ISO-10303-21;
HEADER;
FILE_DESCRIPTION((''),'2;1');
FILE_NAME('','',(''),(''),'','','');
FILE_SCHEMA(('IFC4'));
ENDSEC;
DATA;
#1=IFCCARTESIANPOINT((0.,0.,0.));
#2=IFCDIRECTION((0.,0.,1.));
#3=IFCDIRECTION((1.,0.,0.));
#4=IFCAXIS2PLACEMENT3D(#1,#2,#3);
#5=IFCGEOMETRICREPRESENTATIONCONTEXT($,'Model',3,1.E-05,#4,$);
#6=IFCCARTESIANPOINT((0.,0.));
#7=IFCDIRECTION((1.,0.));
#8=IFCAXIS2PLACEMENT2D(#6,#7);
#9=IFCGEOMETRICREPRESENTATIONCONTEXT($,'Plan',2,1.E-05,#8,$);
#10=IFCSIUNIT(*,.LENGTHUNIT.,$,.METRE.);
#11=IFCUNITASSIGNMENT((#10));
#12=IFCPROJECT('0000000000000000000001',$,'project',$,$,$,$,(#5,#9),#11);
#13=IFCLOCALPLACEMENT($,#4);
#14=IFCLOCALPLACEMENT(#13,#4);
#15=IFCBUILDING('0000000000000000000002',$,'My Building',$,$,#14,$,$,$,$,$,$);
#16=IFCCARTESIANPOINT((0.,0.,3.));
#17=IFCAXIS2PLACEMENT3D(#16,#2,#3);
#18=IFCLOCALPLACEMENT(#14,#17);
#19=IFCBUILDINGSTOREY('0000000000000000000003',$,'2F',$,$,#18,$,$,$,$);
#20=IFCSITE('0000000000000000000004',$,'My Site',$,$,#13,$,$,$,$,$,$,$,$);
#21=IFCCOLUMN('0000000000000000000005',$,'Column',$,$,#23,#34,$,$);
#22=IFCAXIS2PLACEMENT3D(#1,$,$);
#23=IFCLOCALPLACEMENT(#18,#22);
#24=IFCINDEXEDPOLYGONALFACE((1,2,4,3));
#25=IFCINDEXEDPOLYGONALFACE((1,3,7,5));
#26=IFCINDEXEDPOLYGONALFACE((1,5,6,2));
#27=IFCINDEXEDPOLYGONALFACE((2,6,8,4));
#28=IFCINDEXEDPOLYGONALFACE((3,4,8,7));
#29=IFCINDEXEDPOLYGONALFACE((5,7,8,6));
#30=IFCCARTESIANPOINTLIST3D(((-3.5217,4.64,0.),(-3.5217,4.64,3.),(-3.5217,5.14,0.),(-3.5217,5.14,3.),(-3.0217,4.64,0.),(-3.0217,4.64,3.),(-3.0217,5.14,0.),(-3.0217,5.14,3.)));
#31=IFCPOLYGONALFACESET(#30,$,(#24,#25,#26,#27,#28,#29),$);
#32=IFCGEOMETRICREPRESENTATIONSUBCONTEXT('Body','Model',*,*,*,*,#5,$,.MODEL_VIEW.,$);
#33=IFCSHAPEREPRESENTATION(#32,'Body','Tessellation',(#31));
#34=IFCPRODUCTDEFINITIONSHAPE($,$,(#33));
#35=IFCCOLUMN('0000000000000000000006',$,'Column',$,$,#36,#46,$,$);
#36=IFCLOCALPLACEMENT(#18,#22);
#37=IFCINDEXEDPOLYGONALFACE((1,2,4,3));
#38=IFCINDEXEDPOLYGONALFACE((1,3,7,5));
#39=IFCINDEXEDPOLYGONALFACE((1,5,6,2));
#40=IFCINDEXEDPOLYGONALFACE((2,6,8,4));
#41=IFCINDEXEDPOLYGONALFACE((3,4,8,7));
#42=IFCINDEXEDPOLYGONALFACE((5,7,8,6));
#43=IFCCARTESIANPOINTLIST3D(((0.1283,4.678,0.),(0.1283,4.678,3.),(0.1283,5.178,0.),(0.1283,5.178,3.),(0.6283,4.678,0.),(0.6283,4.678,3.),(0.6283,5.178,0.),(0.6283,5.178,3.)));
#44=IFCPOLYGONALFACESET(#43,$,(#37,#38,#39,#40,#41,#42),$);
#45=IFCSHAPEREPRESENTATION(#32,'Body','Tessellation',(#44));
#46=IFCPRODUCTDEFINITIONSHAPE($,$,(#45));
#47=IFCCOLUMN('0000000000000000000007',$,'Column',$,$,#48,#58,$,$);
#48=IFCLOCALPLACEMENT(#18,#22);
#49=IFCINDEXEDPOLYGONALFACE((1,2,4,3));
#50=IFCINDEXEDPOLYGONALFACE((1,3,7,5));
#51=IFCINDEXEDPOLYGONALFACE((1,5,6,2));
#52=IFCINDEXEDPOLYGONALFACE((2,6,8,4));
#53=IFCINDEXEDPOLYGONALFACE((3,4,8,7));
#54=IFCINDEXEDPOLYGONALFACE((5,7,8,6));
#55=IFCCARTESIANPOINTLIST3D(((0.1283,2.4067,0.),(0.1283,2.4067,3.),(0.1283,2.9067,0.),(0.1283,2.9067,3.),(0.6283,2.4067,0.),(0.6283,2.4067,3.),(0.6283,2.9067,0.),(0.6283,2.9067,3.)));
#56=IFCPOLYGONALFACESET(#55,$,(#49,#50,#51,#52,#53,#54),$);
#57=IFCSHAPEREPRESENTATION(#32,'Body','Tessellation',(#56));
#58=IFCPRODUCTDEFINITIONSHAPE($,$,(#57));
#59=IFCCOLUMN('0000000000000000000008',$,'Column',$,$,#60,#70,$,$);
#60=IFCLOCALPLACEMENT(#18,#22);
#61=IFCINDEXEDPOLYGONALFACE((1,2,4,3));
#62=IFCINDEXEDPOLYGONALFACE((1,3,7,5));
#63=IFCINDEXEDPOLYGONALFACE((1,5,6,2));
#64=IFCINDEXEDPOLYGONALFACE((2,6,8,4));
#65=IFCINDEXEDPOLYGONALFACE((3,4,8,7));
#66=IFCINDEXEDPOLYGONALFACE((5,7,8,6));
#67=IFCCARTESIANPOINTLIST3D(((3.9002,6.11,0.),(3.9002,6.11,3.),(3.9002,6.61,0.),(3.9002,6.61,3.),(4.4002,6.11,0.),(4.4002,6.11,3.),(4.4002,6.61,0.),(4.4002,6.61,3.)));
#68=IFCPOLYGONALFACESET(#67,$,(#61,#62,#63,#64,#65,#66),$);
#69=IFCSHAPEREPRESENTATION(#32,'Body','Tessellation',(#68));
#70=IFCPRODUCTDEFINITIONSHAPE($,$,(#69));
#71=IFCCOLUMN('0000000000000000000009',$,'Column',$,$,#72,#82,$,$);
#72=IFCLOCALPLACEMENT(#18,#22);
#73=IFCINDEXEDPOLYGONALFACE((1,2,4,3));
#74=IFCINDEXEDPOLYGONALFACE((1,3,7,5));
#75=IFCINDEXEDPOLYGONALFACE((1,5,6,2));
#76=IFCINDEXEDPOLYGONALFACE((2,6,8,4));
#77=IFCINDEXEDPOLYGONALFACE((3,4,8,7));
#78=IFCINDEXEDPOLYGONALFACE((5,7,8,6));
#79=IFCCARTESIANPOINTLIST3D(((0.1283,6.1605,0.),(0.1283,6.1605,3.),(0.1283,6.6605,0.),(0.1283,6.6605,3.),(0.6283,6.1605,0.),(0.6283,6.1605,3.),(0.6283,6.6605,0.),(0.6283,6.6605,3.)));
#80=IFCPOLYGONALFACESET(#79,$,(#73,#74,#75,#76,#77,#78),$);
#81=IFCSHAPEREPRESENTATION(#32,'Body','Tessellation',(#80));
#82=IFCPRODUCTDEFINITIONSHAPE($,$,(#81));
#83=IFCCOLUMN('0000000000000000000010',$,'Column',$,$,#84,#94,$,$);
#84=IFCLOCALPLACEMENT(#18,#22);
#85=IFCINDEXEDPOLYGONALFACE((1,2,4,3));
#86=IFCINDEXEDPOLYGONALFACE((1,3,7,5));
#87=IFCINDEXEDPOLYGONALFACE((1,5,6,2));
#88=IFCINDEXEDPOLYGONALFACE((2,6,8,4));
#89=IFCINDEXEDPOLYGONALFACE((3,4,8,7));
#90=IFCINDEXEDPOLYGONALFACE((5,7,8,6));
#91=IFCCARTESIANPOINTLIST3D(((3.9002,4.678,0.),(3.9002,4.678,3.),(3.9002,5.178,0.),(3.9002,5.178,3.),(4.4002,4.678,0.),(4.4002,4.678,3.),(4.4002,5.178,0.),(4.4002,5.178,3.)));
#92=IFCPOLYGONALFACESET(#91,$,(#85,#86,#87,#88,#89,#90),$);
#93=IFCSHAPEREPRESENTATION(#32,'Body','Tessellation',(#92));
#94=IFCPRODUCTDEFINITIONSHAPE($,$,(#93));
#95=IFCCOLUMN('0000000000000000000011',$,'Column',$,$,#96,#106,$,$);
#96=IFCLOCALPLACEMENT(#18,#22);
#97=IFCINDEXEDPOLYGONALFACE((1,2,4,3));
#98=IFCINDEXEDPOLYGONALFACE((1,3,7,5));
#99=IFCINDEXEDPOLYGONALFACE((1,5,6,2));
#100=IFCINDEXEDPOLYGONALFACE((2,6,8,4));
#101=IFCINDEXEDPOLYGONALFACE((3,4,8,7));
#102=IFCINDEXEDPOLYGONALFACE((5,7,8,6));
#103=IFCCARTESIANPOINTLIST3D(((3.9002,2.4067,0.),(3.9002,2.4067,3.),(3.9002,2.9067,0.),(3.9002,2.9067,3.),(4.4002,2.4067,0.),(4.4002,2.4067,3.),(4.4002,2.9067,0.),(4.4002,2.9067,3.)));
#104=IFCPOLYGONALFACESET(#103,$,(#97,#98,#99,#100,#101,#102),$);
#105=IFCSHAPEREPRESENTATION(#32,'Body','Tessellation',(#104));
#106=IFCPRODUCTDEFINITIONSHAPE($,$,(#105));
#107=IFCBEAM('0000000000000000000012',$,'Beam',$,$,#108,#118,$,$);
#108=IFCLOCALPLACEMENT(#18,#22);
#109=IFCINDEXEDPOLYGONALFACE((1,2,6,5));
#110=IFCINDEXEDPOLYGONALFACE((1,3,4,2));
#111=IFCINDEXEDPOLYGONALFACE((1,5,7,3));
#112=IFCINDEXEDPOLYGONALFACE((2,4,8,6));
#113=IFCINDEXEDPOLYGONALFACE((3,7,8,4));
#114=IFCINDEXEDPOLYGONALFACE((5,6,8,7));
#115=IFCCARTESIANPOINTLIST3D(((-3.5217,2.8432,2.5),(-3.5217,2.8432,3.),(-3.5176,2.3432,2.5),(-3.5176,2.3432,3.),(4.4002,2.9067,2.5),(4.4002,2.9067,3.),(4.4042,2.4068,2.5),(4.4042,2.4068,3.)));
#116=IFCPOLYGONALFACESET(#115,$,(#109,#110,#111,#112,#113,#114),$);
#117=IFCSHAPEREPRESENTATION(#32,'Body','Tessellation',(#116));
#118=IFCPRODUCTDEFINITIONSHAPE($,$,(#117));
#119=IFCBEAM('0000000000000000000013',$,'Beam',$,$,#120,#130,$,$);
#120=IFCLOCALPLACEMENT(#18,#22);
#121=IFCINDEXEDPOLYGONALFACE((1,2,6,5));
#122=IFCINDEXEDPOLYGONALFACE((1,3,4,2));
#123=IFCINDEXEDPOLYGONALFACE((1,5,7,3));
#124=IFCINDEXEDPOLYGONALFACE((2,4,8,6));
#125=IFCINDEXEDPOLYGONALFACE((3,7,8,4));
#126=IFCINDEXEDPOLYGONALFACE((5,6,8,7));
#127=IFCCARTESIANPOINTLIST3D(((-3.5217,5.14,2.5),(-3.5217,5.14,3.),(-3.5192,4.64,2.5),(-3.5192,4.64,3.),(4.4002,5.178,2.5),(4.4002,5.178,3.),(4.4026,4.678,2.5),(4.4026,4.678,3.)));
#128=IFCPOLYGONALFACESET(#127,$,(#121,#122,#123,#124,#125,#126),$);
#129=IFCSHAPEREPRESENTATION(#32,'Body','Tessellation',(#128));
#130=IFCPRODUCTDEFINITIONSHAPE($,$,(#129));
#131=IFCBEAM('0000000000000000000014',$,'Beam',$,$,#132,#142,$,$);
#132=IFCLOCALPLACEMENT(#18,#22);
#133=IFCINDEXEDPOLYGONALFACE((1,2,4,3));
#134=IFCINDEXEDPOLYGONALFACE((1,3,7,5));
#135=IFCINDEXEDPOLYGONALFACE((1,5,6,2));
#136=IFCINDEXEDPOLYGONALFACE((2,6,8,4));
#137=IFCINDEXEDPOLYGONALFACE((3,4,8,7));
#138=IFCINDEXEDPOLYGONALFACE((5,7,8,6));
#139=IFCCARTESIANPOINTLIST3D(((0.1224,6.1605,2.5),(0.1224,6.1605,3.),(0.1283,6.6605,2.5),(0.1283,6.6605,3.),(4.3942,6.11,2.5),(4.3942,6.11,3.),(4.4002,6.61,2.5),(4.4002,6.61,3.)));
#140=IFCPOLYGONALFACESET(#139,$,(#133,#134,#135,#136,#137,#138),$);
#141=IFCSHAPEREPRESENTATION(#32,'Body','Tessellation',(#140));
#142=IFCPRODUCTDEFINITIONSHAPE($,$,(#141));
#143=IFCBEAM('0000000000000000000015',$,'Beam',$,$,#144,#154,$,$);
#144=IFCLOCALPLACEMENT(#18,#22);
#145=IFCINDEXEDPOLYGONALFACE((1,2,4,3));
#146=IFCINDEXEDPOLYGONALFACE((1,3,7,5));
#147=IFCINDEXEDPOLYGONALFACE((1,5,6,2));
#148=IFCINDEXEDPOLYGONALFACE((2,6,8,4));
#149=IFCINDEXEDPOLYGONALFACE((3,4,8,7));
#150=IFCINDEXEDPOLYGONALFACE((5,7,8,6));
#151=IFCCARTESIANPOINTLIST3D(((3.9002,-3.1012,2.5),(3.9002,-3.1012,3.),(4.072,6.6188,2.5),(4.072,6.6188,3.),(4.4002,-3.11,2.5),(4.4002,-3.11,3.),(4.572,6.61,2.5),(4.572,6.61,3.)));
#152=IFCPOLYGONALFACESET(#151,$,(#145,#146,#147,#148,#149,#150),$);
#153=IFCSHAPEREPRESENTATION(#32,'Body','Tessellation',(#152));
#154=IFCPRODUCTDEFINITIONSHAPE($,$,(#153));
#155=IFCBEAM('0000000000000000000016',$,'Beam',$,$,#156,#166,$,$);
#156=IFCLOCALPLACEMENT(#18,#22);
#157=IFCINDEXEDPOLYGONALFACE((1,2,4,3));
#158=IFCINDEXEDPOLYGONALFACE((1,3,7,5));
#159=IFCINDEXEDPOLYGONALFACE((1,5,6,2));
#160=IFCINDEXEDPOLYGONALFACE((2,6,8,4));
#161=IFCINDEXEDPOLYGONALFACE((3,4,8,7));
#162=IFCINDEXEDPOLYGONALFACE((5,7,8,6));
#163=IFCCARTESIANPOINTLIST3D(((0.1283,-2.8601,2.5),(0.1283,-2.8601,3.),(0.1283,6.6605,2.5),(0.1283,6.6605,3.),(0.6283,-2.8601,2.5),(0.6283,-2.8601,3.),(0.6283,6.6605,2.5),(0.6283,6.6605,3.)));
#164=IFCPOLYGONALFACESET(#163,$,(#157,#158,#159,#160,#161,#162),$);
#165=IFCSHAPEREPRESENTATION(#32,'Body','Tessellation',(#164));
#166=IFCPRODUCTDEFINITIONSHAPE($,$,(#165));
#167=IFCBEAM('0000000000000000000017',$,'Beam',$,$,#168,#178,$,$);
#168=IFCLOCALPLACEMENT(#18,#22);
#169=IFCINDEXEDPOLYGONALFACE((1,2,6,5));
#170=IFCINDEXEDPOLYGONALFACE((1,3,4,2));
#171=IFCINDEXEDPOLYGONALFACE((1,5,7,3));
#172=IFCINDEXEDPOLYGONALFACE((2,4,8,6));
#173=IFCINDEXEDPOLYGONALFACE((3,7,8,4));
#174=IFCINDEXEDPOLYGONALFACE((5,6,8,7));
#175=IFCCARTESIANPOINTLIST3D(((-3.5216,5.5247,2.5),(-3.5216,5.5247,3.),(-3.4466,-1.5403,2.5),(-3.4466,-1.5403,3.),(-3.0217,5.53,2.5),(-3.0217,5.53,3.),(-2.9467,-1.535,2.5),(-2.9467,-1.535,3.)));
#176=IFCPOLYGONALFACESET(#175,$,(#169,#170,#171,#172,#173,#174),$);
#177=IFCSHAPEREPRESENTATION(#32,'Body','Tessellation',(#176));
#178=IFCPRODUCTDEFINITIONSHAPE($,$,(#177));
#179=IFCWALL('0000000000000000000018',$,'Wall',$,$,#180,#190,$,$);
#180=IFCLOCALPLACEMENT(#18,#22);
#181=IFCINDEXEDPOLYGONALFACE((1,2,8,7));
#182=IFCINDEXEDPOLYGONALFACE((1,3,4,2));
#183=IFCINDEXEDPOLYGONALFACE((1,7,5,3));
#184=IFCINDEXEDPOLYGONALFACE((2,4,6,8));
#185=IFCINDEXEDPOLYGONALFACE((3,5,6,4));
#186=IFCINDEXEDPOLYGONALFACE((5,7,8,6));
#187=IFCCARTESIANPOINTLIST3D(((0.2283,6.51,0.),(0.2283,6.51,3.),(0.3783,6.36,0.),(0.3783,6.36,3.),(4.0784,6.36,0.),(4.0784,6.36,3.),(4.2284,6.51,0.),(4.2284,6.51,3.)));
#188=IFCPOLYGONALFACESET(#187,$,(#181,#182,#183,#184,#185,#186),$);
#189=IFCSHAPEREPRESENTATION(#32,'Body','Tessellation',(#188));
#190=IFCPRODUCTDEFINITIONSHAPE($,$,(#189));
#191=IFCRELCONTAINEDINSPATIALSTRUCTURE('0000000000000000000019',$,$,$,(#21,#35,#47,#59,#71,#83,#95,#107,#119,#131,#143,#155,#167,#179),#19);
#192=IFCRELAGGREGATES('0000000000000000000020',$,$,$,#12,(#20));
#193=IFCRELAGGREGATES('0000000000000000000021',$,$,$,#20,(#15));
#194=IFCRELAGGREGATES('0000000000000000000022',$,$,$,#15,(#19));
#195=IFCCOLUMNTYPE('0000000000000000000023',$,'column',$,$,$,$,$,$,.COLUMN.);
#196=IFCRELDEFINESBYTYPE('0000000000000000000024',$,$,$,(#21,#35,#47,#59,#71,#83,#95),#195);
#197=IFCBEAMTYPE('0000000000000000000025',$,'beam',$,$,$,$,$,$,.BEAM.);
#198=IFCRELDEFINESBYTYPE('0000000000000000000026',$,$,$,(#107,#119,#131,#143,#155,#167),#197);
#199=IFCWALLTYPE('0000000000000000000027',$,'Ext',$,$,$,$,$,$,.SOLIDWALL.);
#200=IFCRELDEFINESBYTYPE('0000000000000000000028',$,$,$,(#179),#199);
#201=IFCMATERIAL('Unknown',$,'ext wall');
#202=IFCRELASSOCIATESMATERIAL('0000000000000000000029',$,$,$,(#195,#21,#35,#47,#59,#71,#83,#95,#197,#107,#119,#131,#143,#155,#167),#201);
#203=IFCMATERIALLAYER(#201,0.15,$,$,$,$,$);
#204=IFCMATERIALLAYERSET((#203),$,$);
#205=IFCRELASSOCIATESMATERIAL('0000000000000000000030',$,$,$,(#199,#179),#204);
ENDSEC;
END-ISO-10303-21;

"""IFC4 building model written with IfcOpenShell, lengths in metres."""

from ifc_helpers import new_model, si_unit, frame, origin_with_axes, origin_2d_with_axis, place, context, subcontext, project, spatial, line, indexed_curve, rectangle, outline, extrude, material, layer, layer_set, layer_usage, material_profile, profile_set, profile_usage, type_object, element, save


model = new_model("IFC4")

# Units and contexts
model_context = context("Model", 3, precision=1e-05, world=origin_with_axes())
plan_context = context("Plan", 2, precision=1e-05, world=origin_2d_with_axis())
body_context_1 = subcontext(model_context, "Body", "Model", "MODEL_VIEW")
ifc_project = project(units=[si_unit("LENGTHUNIT", "METRE")], contexts=[model_context, plan_context])

# Site, building, storey
site_placement = place(None, origin_with_axes())
site = spatial("IfcSite", under=ifc_project, at=site_placement, Name="My Site")
building_placement = place(site_placement, origin_with_axes())
building = spatial("IfcBuilding", under=site, at=building_placement, Name="My Building")
storey_placement = place(building_placement, frame((0.0, 0.0, 3.0), z_axis=(0.0, 0.0, 1.0), x_axis=(1.0, 0.0, 0.0)))
storey = spatial("IfcBuildingStorey", under=building, at=storey_placement, Name="2F")

# Columns
ifc_material = material(Name="Unknown", Category="ext wall")
ifc_material_profile_1 = material_profile(ifc_material, rectangle(XDim=0.5, YDim=0.5))
ifc_profile_set_1 = profile_set([ifc_material_profile_1])
ifc_profile_usage_1 = profile_usage(ifc_profile_set_1, cardinal=5)
column_type = type_object("IfcColumnType", Name="column", PredefinedType="COLUMN", material=ifc_profile_set_1)
column_1_placement = place(storey_placement, frame((-3.2717, 4.89, 0.0), z_axis=(0.0, 0.0, 1.0), x_axis=(1.0, 0.0, 0.0)))
element("IfcColumn", 1, at=column_1_placement, inside=storey, type_object=column_type, material=ifc_profile_usage_1, Name="Column", context=body_context_1, shape_type="SweptSolid", body=[
    extrude(rectangle(XDim=0.5, YDim=0.5), origin_with_axes(), (0.0, 0.0, 1.0), 3.0),
])
ifc_profile_usage_2 = profile_usage(ifc_profile_set_1, cardinal=5)
column_2_placement = place(storey_placement, frame((0.3783, 4.928, 0.0), z_axis=(0.0, 0.0, 1.0), x_axis=(1.0, 0.0, 0.0)))
element("IfcColumn", 2, at=column_2_placement, inside=storey, type_object=column_type, material=ifc_profile_usage_2, Name="Column", context=body_context_1, shape_type="SweptSolid", body=[
    extrude(rectangle(XDim=0.5, YDim=0.5), origin_with_axes(), (0.0, 0.0, 1.0), 3.0),
])
ifc_profile_usage_3 = profile_usage(ifc_profile_set_1, cardinal=5)
column_3_placement = place(storey_placement, frame((0.3783, 2.6567, 0.0), z_axis=(0.0, 0.0, 1.0), x_axis=(1.0, 0.0, 0.0)))
element("IfcColumn", 3, at=column_3_placement, inside=storey, type_object=column_type, material=ifc_profile_usage_3, Name="Column", context=body_context_1, shape_type="SweptSolid", body=[
    extrude(rectangle(XDim=0.5, YDim=0.5), origin_with_axes(), (0.0, 0.0, 1.0), 3.0),
])
ifc_profile_usage_4 = profile_usage(ifc_profile_set_1, cardinal=5)
column_4_placement = place(storey_placement, frame((4.1502, 6.36, 0.0), z_axis=(0.0, 0.0, 1.0), x_axis=(1.0, 0.0, 0.0)))
element("IfcColumn", 4, at=column_4_placement, inside=storey, type_object=column_type, material=ifc_profile_usage_4, Name="Column", context=body_context_1, shape_type="SweptSolid", body=[
    extrude(rectangle(XDim=0.5, YDim=0.5), origin_with_axes(), (0.0, 0.0, 1.0), 3.0),
])
ifc_profile_usage_5 = profile_usage(ifc_profile_set_1, cardinal=5)
column_5_placement = place(storey_placement, frame((0.3783, 6.4105, 0.0), z_axis=(0.0, 0.0, 1.0), x_axis=(1.0, 0.0, 0.0)))
element("IfcColumn", 5, at=column_5_placement, inside=storey, type_object=column_type, material=ifc_profile_usage_5, Name="Column", context=body_context_1, shape_type="SweptSolid", body=[
    extrude(rectangle(XDim=0.5, YDim=0.5), origin_with_axes(), (0.0, 0.0, 1.0), 3.0),
])
ifc_profile_usage_6 = profile_usage(ifc_profile_set_1, cardinal=5)
column_6_placement = place(storey_placement, frame((4.1502, 4.928, 0.0), z_axis=(0.0, 0.0, 1.0), x_axis=(1.0, 0.0, 0.0)))
element("IfcColumn", 6, at=column_6_placement, inside=storey, type_object=column_type, material=ifc_profile_usage_6, Name="Column", context=body_context_1, shape_type="SweptSolid", body=[
    extrude(rectangle(XDim=0.5, YDim=0.5), origin_with_axes(), (0.0, 0.0, 1.0), 3.0),
])
ifc_profile_usage_7 = profile_usage(ifc_profile_set_1, cardinal=5)
column_7_placement = place(storey_placement, frame((4.1502, 2.6567, 0.0), z_axis=(0.0, 0.0, 1.0), x_axis=(1.0, 0.0, 0.0)))
element("IfcColumn", 7, at=column_7_placement, inside=storey, type_object=column_type, material=ifc_profile_usage_7, Name="Column", context=body_context_1, shape_type="SweptSolid", body=[
    extrude(rectangle(XDim=0.5, YDim=0.5), origin_with_axes(), (0.0, 0.0, 1.0), 3.0),
])

# Beams
ifc_material_profile_2 = material_profile(ifc_material, rectangle(XDim=0.5, YDim=0.5))
ifc_profile_set_2 = profile_set([ifc_material_profile_2])
ifc_profile_usage_8 = profile_usage(ifc_profile_set_2, cardinal=7)
beam_type = type_object("IfcBeamType", Name="beam", PredefinedType="BEAM", material=ifc_profile_set_2)
beam_1_placement = place(storey_placement, frame((-3.5217, 2.8432, 3.0), z_axis=(0.999968, 0.008024, 0.0), x_axis=(-0.008024, 0.999968, 0.0)))
element("IfcBeam", 8, at=beam_1_placement, inside=storey, type_object=beam_type, material=ifc_profile_usage_8, Name="Beam", context=body_context_1, shape_type="SweptSolid", body=[
    extrude(rectangle(XDim=0.5, YDim=0.5), frame((-0.25, -0.25, 0.0), z_axis=(0.0, 0.0, 1.0), x_axis=(1.0, 0.0, 0.0)), (0.0, 0.0, 1.0), 7.9221),
])
ifc_profile_usage_9 = profile_usage(ifc_profile_set_2, cardinal=7)
beam_2_placement = place(storey_placement, frame((-3.5217, 5.14, 3.0), z_axis=(0.999988, 0.004801, 0.0), x_axis=(-0.004801, 0.999988, 0.0)))
element("IfcBeam", 9, at=beam_2_placement, inside=storey, type_object=beam_type, material=ifc_profile_usage_9, Name="Beam", context=body_context_1, shape_type="SweptSolid", body=[
    extrude(rectangle(XDim=0.5, YDim=0.5), frame((-0.25, -0.25, 0.0), z_axis=(0.0, 0.0, 1.0), x_axis=(1.0, 0.0, 0.0)), (0.0, 0.0, 1.0), 7.9219),
])
ifc_profile_usage_10 = profile_usage(ifc_profile_set_2, cardinal=7)
beam_3_placement = place(storey_placement, frame((0.1283, 6.6605, 3.0), z_axis=(0.99993, -0.011821, 0.0), x_axis=(0.011821, 0.99993, 0.0)))
element("IfcBeam", 10, at=beam_3_placement, inside=storey, type_object=beam_type, material=ifc_profile_usage_10, Name="Beam", context=body_context_1, shape_type="SweptSolid", body=[
    extrude(rectangle(XDim=0.5, YDim=0.5), frame((-0.25, -0.25, 0.0), z_axis=(0.0, 0.0, 1.0), x_axis=(1.0, 0.0, 0.0)), (0.0, 0.0, 1.0), 4.2721),
])
ifc_profile_usage_11 = profile_usage(ifc_profile_set_2, cardinal=7)
beam_4_placement = place(storey_placement, frame((4.572, 6.61, 3.0), z_axis=(-0.017673, -0.999844, 0.0), x_axis=(0.999844, -0.017673, 0.0)))
element("IfcBeam", 11, at=beam_4_placement, inside=storey, type_object=beam_type, material=ifc_profile_usage_11, Name="Beam", context=body_context_1, shape_type="SweptSolid", body=[
    extrude(rectangle(XDim=0.5, YDim=0.5), frame((-0.25, -0.25, 0.0), z_axis=(0.0, 0.0, 1.0), x_axis=(1.0, 0.0, 0.0)), (0.0, 0.0, 1.0), 9.7216),
])
ifc_profile_usage_12 = profile_usage(ifc_profile_set_2, cardinal=7)
beam_5_placement = place(storey_placement, frame((0.6283, 6.6605, 3.0), z_axis=(0.0, -1.0, 0.0), x_axis=(1.0, 0.0, 0.0)))
element("IfcBeam", 12, at=beam_5_placement, inside=storey, type_object=beam_type, material=ifc_profile_usage_12, Name="Beam", context=body_context_1, shape_type="SweptSolid", body=[
    extrude(rectangle(XDim=0.5, YDim=0.5), frame((-0.25, -0.25, 0.0), z_axis=(0.0, 0.0, 1.0), x_axis=(1.0, 0.0, 0.0)), (0.0, 0.0, 1.0), 9.5206),
])
ifc_profile_usage_13 = profile_usage(ifc_profile_set_2, cardinal=7)
beam_6_placement = place(storey_placement, frame((-3.0217, 5.53, 3.0), z_axis=(0.010615, -0.999944, 0.0), x_axis=(0.999944, 0.010615, 0.0)))
element("IfcBeam", 13, at=beam_6_placement, inside=storey, type_object=beam_type, material=ifc_profile_usage_13, Name="Beam", context=body_context_1, shape_type="SweptSolid", body=[
    extrude(rectangle(XDim=0.5, YDim=0.5), frame((-0.25, -0.25, 0.0), z_axis=(0.0, 0.0, 1.0), x_axis=(1.0, 0.0, 0.0)), (0.0, 0.0, 1.0), 7.0654),
])

# Wall
ifc_layer_1 = layer(ifc_material, 0.15)
ifc_layer_set_1 = layer_set([ifc_layer_1])
ifc_layer_usage_1 = layer_usage(ifc_layer_set_1, "AXIS2", "POSITIVE", 0.0)
wall_type_1 = type_object("IfcWallType", Name="Ext", PredefinedType="SOLIDWALL", material=ifc_layer_set_1)
wall_1_placement = place(storey_placement, frame((4.2284, 6.51, 0.0), z_axis=(0.0, 0.0, 1.0), x_axis=(-1.0, 0.0, 0.0)))
element("IfcWall", 14, at=wall_1_placement, inside=storey, type_object=wall_type_1, material=ifc_layer_usage_1, Name="Wall", context=body_context_1, shape_type="SweptSolid", body=[
    extrude(outline(indexed_curve([(0.0, 0.0), (0.15, 0.15), (3.85, 0.15), (4.0, 0.0)], segments=[line(1, 2, 3, 4, 1)])), origin_with_axes(), (0.0, 0.0, 1.0), 3.0),
])

save(model, "model.ifc")
